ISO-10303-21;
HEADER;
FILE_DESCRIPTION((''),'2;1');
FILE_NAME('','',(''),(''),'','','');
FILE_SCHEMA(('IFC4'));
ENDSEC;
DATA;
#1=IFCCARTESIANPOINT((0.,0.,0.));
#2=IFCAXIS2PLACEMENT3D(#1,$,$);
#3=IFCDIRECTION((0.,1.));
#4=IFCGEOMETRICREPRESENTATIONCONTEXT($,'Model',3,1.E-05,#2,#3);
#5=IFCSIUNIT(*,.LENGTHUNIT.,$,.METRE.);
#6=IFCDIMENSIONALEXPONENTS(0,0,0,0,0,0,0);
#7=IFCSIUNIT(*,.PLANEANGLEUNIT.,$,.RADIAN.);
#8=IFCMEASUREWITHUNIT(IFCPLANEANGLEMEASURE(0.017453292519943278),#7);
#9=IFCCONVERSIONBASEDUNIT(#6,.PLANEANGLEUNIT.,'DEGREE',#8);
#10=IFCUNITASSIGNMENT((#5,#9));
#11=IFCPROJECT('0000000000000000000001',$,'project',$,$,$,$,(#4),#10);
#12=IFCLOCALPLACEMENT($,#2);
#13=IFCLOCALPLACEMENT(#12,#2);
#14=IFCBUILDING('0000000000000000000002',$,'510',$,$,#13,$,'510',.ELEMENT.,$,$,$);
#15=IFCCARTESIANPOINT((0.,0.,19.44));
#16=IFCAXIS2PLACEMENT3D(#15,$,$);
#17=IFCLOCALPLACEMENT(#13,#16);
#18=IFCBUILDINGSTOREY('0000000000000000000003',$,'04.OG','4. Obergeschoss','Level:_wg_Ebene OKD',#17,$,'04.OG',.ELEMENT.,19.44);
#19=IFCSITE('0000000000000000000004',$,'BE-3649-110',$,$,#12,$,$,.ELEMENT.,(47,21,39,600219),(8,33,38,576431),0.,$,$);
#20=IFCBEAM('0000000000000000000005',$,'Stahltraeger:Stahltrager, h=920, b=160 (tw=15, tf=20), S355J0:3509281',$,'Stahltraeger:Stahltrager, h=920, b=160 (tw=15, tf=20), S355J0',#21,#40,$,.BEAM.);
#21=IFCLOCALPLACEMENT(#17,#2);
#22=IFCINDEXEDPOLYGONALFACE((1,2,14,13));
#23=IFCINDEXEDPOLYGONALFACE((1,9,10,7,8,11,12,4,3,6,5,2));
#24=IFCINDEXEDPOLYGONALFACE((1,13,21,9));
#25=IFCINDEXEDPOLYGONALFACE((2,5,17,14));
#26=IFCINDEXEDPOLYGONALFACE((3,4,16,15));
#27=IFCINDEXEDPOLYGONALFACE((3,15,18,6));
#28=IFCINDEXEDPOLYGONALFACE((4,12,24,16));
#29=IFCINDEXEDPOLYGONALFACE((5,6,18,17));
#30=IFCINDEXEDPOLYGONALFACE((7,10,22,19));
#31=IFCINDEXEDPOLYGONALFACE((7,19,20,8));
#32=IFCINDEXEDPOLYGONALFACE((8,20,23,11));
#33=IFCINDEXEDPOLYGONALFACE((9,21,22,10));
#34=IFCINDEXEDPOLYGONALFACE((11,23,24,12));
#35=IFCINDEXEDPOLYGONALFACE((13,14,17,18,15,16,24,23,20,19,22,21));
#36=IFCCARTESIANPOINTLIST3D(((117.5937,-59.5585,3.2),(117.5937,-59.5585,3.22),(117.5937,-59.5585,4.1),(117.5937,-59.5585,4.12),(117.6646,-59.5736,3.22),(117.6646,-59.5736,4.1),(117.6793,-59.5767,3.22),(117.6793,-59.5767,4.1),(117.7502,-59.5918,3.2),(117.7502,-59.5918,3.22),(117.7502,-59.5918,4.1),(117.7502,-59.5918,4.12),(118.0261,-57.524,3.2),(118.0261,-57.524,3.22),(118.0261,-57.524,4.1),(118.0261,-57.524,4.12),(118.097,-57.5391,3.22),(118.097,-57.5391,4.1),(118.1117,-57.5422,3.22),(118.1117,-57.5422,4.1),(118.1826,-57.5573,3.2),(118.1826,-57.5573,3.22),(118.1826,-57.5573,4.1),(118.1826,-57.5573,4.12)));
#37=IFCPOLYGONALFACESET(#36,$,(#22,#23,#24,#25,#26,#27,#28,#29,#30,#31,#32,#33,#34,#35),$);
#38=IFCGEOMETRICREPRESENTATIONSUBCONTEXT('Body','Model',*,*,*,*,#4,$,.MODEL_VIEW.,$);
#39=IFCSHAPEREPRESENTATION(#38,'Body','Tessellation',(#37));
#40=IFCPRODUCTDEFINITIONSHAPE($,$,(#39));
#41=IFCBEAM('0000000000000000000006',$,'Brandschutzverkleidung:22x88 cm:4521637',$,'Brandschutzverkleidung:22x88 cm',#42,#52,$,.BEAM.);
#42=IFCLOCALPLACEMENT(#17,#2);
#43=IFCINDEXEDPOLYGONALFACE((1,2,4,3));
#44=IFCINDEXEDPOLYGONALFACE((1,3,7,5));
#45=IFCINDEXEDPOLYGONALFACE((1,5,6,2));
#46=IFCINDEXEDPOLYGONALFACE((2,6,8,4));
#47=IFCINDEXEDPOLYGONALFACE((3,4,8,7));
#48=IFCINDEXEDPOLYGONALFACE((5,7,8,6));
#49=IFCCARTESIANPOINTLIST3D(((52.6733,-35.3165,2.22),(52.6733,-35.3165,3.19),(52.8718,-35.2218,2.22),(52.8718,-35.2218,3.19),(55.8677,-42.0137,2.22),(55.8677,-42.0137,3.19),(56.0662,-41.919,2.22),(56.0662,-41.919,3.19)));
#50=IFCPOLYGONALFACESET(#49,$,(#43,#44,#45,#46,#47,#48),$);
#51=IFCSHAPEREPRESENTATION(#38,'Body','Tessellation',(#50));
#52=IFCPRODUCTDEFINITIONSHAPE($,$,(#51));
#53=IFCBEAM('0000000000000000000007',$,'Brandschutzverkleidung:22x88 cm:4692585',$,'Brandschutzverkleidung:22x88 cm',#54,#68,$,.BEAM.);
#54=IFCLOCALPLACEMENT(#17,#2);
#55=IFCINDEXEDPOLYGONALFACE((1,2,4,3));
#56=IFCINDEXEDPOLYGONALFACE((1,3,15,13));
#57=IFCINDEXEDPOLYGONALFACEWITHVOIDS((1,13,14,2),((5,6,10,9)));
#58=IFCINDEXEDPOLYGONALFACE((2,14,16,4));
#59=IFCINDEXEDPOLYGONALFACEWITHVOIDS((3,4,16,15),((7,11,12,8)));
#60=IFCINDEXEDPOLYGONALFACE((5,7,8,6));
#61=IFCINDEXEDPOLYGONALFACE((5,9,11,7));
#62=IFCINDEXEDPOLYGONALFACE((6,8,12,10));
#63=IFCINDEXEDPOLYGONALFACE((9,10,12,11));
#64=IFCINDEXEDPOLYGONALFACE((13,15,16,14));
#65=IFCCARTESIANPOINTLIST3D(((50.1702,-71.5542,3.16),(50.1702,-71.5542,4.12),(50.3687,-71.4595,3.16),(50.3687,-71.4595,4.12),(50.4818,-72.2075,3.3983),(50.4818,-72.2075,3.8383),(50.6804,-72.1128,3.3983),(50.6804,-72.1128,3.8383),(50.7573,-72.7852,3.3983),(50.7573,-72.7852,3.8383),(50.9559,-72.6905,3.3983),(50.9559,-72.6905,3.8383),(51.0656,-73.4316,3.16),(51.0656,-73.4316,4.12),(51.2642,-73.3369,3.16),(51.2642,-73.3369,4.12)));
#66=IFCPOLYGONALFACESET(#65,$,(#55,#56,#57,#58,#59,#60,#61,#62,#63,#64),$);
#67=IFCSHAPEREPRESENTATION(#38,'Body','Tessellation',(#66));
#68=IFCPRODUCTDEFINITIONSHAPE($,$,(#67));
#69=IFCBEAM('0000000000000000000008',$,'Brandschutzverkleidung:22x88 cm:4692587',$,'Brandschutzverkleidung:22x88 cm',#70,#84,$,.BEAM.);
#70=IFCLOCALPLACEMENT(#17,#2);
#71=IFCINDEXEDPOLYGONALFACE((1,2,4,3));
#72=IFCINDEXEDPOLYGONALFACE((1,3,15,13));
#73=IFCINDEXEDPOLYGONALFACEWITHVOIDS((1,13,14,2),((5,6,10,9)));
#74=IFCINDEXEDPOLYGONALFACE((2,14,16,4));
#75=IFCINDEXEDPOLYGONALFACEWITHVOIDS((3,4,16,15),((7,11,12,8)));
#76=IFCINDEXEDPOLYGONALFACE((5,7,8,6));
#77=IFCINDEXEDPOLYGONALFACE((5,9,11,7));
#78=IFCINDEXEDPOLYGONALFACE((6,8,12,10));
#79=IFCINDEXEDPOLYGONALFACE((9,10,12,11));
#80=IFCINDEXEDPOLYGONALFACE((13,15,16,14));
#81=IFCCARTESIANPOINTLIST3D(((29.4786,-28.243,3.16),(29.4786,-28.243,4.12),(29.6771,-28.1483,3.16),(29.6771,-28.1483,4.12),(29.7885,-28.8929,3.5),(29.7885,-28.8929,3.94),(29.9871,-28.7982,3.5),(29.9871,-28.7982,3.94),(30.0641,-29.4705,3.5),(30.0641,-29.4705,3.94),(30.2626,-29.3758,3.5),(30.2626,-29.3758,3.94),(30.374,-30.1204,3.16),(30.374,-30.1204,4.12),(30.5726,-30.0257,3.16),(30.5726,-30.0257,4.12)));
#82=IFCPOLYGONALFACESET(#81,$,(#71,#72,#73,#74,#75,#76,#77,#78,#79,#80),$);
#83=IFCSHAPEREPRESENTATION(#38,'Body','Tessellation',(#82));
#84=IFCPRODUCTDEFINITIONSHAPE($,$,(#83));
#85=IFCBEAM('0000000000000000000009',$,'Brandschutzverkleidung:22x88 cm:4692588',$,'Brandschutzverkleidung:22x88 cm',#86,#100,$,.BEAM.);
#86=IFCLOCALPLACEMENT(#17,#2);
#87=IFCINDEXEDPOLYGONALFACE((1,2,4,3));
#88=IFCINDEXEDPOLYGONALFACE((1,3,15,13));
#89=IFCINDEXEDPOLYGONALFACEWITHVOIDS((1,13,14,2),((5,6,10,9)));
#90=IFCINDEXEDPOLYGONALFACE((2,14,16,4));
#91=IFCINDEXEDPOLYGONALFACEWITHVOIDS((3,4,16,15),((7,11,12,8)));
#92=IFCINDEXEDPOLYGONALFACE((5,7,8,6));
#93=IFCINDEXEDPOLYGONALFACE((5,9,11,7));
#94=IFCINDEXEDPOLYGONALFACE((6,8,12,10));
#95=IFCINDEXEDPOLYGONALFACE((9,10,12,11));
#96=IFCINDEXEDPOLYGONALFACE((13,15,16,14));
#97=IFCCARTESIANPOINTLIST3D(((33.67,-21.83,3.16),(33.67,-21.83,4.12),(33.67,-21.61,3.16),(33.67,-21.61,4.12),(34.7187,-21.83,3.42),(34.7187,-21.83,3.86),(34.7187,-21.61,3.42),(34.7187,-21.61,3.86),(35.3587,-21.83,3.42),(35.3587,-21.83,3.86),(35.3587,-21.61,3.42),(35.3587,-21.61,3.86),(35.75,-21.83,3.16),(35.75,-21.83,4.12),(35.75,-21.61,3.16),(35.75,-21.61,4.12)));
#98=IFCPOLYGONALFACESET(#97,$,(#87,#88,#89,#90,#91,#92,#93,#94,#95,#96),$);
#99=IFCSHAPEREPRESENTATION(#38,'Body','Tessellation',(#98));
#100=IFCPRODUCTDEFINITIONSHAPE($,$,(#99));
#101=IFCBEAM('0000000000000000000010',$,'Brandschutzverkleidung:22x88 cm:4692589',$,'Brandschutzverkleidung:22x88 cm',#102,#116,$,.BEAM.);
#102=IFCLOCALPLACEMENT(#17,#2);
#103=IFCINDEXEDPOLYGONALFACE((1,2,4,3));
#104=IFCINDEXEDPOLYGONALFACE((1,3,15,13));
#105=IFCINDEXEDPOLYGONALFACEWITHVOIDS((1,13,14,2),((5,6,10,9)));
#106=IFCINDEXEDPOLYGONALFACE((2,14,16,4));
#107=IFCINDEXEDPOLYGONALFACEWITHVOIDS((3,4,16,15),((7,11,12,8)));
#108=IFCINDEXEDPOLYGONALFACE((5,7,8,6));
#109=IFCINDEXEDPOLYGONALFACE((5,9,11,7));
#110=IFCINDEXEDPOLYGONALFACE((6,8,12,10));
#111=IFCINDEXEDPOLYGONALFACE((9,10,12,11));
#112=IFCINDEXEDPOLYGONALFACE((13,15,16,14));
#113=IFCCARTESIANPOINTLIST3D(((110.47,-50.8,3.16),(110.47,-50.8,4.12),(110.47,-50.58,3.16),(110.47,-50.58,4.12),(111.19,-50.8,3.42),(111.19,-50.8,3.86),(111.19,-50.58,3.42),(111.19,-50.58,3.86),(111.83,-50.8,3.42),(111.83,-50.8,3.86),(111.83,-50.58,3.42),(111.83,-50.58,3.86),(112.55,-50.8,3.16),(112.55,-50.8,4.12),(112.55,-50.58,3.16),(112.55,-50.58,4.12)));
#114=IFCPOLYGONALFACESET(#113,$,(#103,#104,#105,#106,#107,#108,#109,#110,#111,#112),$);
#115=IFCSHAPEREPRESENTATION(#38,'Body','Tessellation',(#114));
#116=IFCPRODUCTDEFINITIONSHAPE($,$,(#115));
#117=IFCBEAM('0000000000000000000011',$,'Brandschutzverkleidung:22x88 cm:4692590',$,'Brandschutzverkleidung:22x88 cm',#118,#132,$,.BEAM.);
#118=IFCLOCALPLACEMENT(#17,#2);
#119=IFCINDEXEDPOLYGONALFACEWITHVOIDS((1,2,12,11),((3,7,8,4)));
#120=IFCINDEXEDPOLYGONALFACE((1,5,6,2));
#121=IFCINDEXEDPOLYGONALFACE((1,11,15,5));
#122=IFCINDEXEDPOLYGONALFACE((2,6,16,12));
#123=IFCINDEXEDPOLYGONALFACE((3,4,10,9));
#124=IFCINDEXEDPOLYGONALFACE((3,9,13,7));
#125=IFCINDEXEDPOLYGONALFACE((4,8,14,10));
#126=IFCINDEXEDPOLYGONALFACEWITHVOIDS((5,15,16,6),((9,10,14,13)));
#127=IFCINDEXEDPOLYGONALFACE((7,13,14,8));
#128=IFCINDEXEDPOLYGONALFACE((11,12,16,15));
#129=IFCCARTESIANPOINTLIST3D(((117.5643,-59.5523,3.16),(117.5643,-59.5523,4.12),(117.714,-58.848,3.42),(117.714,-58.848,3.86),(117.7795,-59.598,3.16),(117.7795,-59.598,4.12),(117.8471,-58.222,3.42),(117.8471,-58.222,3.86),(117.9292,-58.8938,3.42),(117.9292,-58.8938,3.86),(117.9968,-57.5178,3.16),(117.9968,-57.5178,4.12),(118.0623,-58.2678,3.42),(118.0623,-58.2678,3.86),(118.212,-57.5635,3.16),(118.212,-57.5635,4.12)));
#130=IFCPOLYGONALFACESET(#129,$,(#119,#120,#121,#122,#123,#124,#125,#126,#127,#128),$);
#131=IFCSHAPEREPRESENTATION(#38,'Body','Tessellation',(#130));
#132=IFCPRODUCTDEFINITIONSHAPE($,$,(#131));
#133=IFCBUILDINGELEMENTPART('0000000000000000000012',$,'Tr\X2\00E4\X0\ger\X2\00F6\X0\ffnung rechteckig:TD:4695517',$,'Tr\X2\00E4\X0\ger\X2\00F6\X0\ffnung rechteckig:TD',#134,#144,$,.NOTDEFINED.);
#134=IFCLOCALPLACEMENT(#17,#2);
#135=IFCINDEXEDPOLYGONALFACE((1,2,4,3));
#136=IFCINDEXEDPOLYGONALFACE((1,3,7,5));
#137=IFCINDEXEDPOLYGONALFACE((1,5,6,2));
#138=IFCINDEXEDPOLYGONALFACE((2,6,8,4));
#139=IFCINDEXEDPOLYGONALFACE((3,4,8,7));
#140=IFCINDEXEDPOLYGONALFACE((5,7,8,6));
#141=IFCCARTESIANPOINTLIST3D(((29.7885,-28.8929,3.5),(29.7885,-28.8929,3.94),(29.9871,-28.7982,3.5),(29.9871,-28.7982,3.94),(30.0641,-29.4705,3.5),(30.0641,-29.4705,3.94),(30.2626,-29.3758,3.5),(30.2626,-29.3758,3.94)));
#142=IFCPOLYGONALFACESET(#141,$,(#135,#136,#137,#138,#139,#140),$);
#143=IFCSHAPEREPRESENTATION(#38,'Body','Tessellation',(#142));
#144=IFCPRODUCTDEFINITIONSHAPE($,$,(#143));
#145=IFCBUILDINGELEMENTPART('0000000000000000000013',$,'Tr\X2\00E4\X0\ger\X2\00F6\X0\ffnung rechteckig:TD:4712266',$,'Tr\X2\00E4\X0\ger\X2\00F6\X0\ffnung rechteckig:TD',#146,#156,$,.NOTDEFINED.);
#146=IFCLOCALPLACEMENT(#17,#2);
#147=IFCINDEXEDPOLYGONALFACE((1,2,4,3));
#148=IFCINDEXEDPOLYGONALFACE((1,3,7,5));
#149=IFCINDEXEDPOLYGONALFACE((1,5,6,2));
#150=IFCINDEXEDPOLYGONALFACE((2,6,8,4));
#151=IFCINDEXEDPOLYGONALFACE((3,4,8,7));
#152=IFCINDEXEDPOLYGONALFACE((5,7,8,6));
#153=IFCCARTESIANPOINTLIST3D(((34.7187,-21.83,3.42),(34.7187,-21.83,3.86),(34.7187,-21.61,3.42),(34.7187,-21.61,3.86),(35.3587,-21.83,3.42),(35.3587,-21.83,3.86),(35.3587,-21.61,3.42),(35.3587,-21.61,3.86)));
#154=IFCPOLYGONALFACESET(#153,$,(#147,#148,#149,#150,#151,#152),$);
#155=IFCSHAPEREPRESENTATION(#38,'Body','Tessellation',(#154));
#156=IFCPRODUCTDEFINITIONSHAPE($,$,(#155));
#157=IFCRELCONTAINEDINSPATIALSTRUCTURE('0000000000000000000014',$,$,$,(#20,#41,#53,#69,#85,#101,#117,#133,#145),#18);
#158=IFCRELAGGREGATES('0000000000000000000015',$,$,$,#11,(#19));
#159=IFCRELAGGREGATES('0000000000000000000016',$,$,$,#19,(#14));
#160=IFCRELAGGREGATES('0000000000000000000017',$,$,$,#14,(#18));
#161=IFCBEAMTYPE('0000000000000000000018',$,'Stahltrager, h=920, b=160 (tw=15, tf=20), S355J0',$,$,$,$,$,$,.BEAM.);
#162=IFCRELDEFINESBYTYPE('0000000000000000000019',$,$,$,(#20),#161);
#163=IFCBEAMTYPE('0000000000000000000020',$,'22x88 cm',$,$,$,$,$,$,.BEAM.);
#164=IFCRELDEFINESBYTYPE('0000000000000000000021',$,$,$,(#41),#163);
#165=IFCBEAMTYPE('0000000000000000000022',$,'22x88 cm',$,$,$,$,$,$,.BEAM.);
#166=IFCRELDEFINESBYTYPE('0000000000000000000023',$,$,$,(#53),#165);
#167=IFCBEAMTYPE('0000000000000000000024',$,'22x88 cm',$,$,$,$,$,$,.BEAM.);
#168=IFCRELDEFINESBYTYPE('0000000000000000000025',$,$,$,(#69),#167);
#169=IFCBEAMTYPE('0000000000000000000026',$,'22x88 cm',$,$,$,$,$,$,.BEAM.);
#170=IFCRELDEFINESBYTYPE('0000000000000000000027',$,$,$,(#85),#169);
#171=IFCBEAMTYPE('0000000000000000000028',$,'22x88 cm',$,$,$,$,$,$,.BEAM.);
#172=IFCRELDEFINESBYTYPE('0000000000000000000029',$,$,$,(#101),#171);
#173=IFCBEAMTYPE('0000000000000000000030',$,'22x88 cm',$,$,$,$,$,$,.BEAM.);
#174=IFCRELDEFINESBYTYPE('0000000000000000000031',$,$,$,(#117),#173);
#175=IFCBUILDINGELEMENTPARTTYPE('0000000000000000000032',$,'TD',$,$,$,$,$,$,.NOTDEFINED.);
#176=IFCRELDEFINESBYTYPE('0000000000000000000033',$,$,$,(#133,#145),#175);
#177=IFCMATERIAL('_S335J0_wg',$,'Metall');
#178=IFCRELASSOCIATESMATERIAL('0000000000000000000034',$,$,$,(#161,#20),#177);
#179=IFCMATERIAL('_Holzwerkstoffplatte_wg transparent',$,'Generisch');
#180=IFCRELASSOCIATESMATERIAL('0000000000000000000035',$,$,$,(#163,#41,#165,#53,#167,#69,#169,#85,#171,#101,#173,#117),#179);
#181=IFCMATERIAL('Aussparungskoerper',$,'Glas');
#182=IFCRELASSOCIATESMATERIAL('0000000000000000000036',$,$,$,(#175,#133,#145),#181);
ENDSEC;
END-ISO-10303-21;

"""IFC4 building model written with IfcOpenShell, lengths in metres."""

from ifc_helpers import new_model, entity, si_unit, converted_unit, direction, frame, origin, place, context, subcontext, project, spatial, indexed_curve, outline, extrude, source, transform, mapped, material, type_object, type_shapes, element, save


model = new_model("IFC4")

# Units and contexts
model_context = context("Model", 3, precision=1e-05, world=origin(), true_north=direction((0.0, 1.0)))
body_context = subcontext(model_context, "Body", "Model", "MODEL_VIEW")
ifc_project = project(units=[si_unit("LENGTHUNIT", "METRE"), converted_unit("PLANEANGLEUNIT", "DEGREE", entity("IfcPlaneAngleMeasure", 0.017453292519943278), si_unit("PLANEANGLEUNIT", "RADIAN"), dimensions=[0, 0, 0, 0, 0, 0, 0])], contexts=[model_context])

# Site, building, storey
site_placement = place(None, origin())
site = spatial("IfcSite", under=ifc_project, at=site_placement, Name="BE-3649-110", CompositionType="ELEMENT", RefLatitude=(47, 21, 39, 600219), RefLongitude=(8, 33, 38, 576431), RefElevation=0.0)
building_placement = place(site_placement, origin())
building = spatial("IfcBuilding", under=site, at=building_placement, Name="510", LongName="510", CompositionType="ELEMENT")
storey_placement = place(building_placement, frame((0.0, 0.0, 19.44)))
storey = spatial("IfcBuildingStorey", under=building, at=storey_placement, Name="04.OG", Description="4. Obergeschoss", ObjectType="Level:_wg_Ebene OKD", LongName="04.OG", CompositionType="ELEMENT", Elevation=19.44)

# Shared definitions
ifc_material_1 = material(Name="_S335J0_wg", Category="Metall")

# Shared definitions
ifc_material_2 = material(Name="_Holzwerkstoffplatte_wg transparent", Category="Generisch")

# Beam, opening
beam_type_1 = type_object("IfcBeamType", Name="Stahltrager, h=920, b=160 (tw=15, tf=20), S355J0", PredefinedType="BEAM", material=ifc_material_1)
shared_shape_1 = source(origin(), body_context, "Body", "SweptSolid", [
    extrude(outline(indexed_curve([(0.44, -0.08), (0.46, -0.08), (0.46, 0.08), (0.44, 0.08), (0.44, 0.0075), (-0.44, 0.0075), (-0.44, 0.08), (-0.46, 0.08), (-0.46, -0.08), (-0.44, -0.08), (-0.44, -0.0075), (0.44, -0.0075), (0.44, -0.08)], self_intersect=False)), frame((0.0783, 0.0166, 0.46), z_axis=(0.207912, 0.978148, 0.0), x_axis=(0.0, 0.0, -1.0)), (0.0, 0.0, 1.0), 2.08),
])
type_shapes(beam_type_1, [shared_shape_1])
beam_1_placement = place(storey_placement, frame((117.5937, -59.5918, 3.2)))
beam_1 = element("IfcBeam", 1, at=beam_1_placement, inside=storey, type_object=beam_type_1, material=ifc_material_1, Name="Stahltraeger:Stahltrager, h=920, b=160 (tw=15, tf=20), S355J0:3509281", ObjectType="Stahltraeger:Stahltrager, h=920, b=160 (tw=15, tf=20), S355J0", PredefinedType="BEAM", context=body_context, shape_type="MappedRepresentation", body=[
    mapped(shared_shape_1, transform((0.0, 0.0, 0.0), scale=1.0)),
])
opening_1_placement = place(storey_placement, frame((117.5937, -59.5918, 3.2)))
element("IfcOpeningElement", 2, at=opening_1_placement, cuts=beam_1, PredefinedType="OPENING", context=body_context, shape_type="SweptSolid", body=[
    extrude(outline(indexed_curve([(-0.32, -0.22), (0.32, -0.22), (0.32, 0.22), (-0.32, 0.22), (-0.32, -0.22)], self_intersect=False)), frame((0.2871, 1.0355, -19.0), z_axis=(0.978148, -0.207912, 0.0), x_axis=(0.207912, 0.978148, 0.0)), (0.0, 0.0, 1.0), 0.015),
])

# Beams
beam_type_2 = type_object("IfcBeamType", Name="22x88 cm", PredefinedType="BEAM", material=ifc_material_2)
shared_shape_2 = source(origin(), body_context, "Body", "SweptSolid", [
    extrude(outline(indexed_curve([(-3.71, -0.11), (3.71, -0.11), (3.71, 0.11), (-3.71, 0.11), (-3.71, -0.11)], self_intersect=False)), frame((54.3698, -38.6177, -0.485), z_axis=(0.0, 0.0, 1.0), x_axis=(0.430511, -0.902585, 0.0)), (0.0, 0.0, 1.0), 0.97),
])
type_shapes(beam_type_2, [shared_shape_2])
beam_2_placement = place(storey_placement, frame((0.0, 0.0, 2.705)))
element("IfcBeam", 3, at=beam_2_placement, inside=storey, type_object=beam_type_2, material=ifc_material_2, Name="Brandschutzverkleidung:22x88 cm:4521637", ObjectType="Brandschutzverkleidung:22x88 cm", PredefinedType="BEAM", context=body_context, shape_type="MappedRepresentation", body=[
    mapped(shared_shape_2, transform((0.0, 0.0, 0.0), scale=1.0)),
])
beam_type_3 = type_object("IfcBeamType", Name="22x88 cm", PredefinedType="BEAM", material=ifc_material_2)
shared_shape_3 = source(origin(), body_context, "Body", "SweptSolid", [
    extrude(outline(indexed_curve([(-1.04, -0.48), (1.04, -0.48), (1.04, 0.48), (-1.04, 0.48), (-1.04, -0.48)], self_intersect=False), holes=[indexed_curve([(0.3238, 0.2417), (0.3238, -0.1983), (-0.3162, -0.1983), (-0.3162, 0.2417), (0.3238, 0.2417)], self_intersect=False)]), frame((50.6179, -72.4929, 0.0), z_axis=(0.902585, 0.430511, 0.0), x_axis=(0.430511, -0.902585, 0.0)), (0.0, 0.0, 1.0), 0.22),
])
type_shapes(beam_type_3, [shared_shape_3])
beam_3_placement = place(storey_placement, frame((0.0, 0.0, 3.64)))
element("IfcBeam", 4, at=beam_3_placement, inside=storey, type_object=beam_type_3, material=ifc_material_2, Name="Brandschutzverkleidung:22x88 cm:4692585", ObjectType="Brandschutzverkleidung:22x88 cm", PredefinedType="BEAM", context=body_context, shape_type="MappedRepresentation", body=[
    mapped(shared_shape_3, transform((0.0, 0.0, 0.0), scale=1.0)),
])
beam_type_4 = type_object("IfcBeamType", Name="22x88 cm", PredefinedType="BEAM", material=ifc_material_2)
shared_shape_4 = source(origin(), body_context, "Body", "SweptSolid", [
    extrude(outline(indexed_curve([(-1.04, -0.48), (1.04, -0.48), (1.04, 0.48), (-1.04, 0.48), (-1.04, -0.48)], self_intersect=False), holes=[indexed_curve([(-0.32, -0.14), (-0.32, 0.3), (0.32, 0.3), (0.32, -0.14), (-0.32, -0.14)], self_intersect=False)]), frame((29.9263, -29.1817, 0.0), z_axis=(0.902585, 0.430511, 0.0), x_axis=(-0.430511, 0.902585, 0.0)), (0.0, 0.0, 1.0), 0.22),
])
type_shapes(beam_type_4, [shared_shape_4])
beam_4_placement = place(storey_placement, frame((0.0, 0.0, 3.64)))
element("IfcBeam", 5, at=beam_4_placement, inside=storey, type_object=beam_type_4, material=ifc_material_2, Name="Brandschutzverkleidung:22x88 cm:4692587", ObjectType="Brandschutzverkleidung:22x88 cm", PredefinedType="BEAM", context=body_context, shape_type="MappedRepresentation", body=[
    mapped(shared_shape_4, transform((0.0, 0.0, 0.0), scale=1.0)),
])
beam_type_5 = type_object("IfcBeamType", Name="22x88 cm", PredefinedType="BEAM", material=ifc_material_2)
shared_shape_5 = source(origin(), body_context, "Body", "SweptSolid", [
    extrude(outline(indexed_curve([(-1.04, -0.48), (1.04, -0.48), (1.04, 0.48), (-1.04, 0.48), (-1.04, -0.48)], self_intersect=False), holes=[indexed_curve([(0.6487, 0.22), (0.6487, -0.22), (0.0087, -0.22), (0.0087, 0.22), (0.6487, 0.22)], self_intersect=False)]), frame((34.71, -21.83, 0.0), z_axis=(0.0, 1.0, 0.0), x_axis=(1.0, 0.0, 0.0)), (0.0, 0.0, 1.0), 0.22),
])
type_shapes(beam_type_5, [shared_shape_5])
beam_5_placement = place(storey_placement, frame((0.0, 0.0, 3.64)))
element("IfcBeam", 6, at=beam_5_placement, inside=storey, type_object=beam_type_5, material=ifc_material_2, Name="Brandschutzverkleidung:22x88 cm:4692588", ObjectType="Brandschutzverkleidung:22x88 cm", PredefinedType="BEAM", context=body_context, shape_type="MappedRepresentation", body=[
    mapped(shared_shape_5, transform((0.0, 0.0, 0.0), scale=1.0)),
])
beam_type_6 = type_object("IfcBeamType", Name="22x88 cm", PredefinedType="BEAM", material=ifc_material_2)
shared_shape_6 = source(origin(), body_context, "Body", "SweptSolid", [
    extrude(outline(indexed_curve([(-1.04, -0.48), (1.04, -0.48), (1.04, 0.48), (-1.04, 0.48), (-1.04, -0.48)], self_intersect=False), holes=[indexed_curve([(0.32, 0.22), (0.32, -0.22), (-0.32, -0.22), (-0.32, 0.22), (0.32, 0.22)], self_intersect=False)]), frame((111.51, -50.8, 0.0), z_axis=(0.0, 1.0, 0.0), x_axis=(1.0, 0.0, 0.0)), (0.0, 0.0, 1.0), 0.22),
])
type_shapes(beam_type_6, [shared_shape_6])
beam_6_placement = place(storey_placement, frame((0.0, 0.0, 3.64)))
element("IfcBeam", 7, at=beam_6_placement, inside=storey, type_object=beam_type_6, material=ifc_material_2, Name="Brandschutzverkleidung:22x88 cm:4692589", ObjectType="Brandschutzverkleidung:22x88 cm", PredefinedType="BEAM", context=body_context, shape_type="MappedRepresentation", body=[
    mapped(shared_shape_6, transform((0.0, 0.0, 0.0), scale=1.0)),
])
beam_type_7 = type_object("IfcBeamType", Name="22x88 cm", PredefinedType="BEAM", material=ifc_material_2)
shared_shape_7 = source(origin(), body_context, "Body", "SweptSolid", [
    extrude(outline(indexed_curve([(-1.04, -0.48), (1.04, -0.48), (1.04, 0.48), (-1.04, 0.48), (-1.04, -0.48)], self_intersect=False), holes=[indexed_curve([(0.32, 0.22), (0.32, -0.22), (-0.32, -0.22), (-0.32, 0.22), (0.32, 0.22)], self_intersect=False)]), frame((117.7806, -58.535, 0.0), z_axis=(0.978148, -0.207912, 0.0), x_axis=(-0.207912, -0.978148, 0.0)), (0.0, 0.0, 1.0), 0.22),
])
type_shapes(beam_type_7, [shared_shape_7])
beam_7_placement = place(storey_placement, frame((0.0, 0.0, 3.64)))
element("IfcBeam", 8, at=beam_7_placement, inside=storey, type_object=beam_type_7, material=ifc_material_2, Name="Brandschutzverkleidung:22x88 cm:4692590", ObjectType="Brandschutzverkleidung:22x88 cm", PredefinedType="BEAM", context=body_context, shape_type="MappedRepresentation", body=[
    mapped(shared_shape_7, transform((0.0, 0.0, 0.0), scale=1.0)),
])

# Building element parts
ifc_material_3 = material(Name="Aussparungskoerper", Category="Glas")
building_element_part_type_1 = type_object("IfcBuildingElementPartType", Name="TD", PredefinedType="NOTDEFINED", material=ifc_material_3)
shared_shape_8 = source(origin(), body_context, "Body", "SweptSolid", [
    extrude(outline(indexed_curve([(-0.22, -0.32), (0.22, -0.32), (0.22, 0.32), (-0.22, 0.32), (-0.22, -0.32)], self_intersect=False)), frame((0.0, 0.0, -0.22), z_axis=(0.0, 0.0, 1.0), x_axis=(0.0, 1.0, 0.0)), (0.0, 0.0, 1.0), 0.22),
])
type_shapes(building_element_part_type_1, [shared_shape_8])
for number, where, z_axis, x_axis, name in (
    (9, (30.1249, -29.087, 3.72), (0.902585, 0.430511, 0.0), (-0.430511, 0.902585, 0.0), "Trägeröffnung rechteckig:TD:4695517"),
    (10, (35.0387, -21.83, 3.64), (0.0, -1.0, 0.0), (1.0, 0.0, 0.0), "Trägeröffnung rechteckig:TD:4712266"),
):
    element("IfcBuildingElementPart", number, at=place(storey_placement, frame(where, z_axis=z_axis, x_axis=x_axis)), inside=storey, type_object=building_element_part_type_1, material=ifc_material_3, Name=name, ObjectType="Trägeröffnung rechteckig:TD", PredefinedType="NOTDEFINED", context=body_context, shape_type="MappedRepresentation", body=[
        mapped(shared_shape_8, transform((0.0, 0.0, 0.0), scale=1.0)),
    ])

save(model, "model.ifc")
